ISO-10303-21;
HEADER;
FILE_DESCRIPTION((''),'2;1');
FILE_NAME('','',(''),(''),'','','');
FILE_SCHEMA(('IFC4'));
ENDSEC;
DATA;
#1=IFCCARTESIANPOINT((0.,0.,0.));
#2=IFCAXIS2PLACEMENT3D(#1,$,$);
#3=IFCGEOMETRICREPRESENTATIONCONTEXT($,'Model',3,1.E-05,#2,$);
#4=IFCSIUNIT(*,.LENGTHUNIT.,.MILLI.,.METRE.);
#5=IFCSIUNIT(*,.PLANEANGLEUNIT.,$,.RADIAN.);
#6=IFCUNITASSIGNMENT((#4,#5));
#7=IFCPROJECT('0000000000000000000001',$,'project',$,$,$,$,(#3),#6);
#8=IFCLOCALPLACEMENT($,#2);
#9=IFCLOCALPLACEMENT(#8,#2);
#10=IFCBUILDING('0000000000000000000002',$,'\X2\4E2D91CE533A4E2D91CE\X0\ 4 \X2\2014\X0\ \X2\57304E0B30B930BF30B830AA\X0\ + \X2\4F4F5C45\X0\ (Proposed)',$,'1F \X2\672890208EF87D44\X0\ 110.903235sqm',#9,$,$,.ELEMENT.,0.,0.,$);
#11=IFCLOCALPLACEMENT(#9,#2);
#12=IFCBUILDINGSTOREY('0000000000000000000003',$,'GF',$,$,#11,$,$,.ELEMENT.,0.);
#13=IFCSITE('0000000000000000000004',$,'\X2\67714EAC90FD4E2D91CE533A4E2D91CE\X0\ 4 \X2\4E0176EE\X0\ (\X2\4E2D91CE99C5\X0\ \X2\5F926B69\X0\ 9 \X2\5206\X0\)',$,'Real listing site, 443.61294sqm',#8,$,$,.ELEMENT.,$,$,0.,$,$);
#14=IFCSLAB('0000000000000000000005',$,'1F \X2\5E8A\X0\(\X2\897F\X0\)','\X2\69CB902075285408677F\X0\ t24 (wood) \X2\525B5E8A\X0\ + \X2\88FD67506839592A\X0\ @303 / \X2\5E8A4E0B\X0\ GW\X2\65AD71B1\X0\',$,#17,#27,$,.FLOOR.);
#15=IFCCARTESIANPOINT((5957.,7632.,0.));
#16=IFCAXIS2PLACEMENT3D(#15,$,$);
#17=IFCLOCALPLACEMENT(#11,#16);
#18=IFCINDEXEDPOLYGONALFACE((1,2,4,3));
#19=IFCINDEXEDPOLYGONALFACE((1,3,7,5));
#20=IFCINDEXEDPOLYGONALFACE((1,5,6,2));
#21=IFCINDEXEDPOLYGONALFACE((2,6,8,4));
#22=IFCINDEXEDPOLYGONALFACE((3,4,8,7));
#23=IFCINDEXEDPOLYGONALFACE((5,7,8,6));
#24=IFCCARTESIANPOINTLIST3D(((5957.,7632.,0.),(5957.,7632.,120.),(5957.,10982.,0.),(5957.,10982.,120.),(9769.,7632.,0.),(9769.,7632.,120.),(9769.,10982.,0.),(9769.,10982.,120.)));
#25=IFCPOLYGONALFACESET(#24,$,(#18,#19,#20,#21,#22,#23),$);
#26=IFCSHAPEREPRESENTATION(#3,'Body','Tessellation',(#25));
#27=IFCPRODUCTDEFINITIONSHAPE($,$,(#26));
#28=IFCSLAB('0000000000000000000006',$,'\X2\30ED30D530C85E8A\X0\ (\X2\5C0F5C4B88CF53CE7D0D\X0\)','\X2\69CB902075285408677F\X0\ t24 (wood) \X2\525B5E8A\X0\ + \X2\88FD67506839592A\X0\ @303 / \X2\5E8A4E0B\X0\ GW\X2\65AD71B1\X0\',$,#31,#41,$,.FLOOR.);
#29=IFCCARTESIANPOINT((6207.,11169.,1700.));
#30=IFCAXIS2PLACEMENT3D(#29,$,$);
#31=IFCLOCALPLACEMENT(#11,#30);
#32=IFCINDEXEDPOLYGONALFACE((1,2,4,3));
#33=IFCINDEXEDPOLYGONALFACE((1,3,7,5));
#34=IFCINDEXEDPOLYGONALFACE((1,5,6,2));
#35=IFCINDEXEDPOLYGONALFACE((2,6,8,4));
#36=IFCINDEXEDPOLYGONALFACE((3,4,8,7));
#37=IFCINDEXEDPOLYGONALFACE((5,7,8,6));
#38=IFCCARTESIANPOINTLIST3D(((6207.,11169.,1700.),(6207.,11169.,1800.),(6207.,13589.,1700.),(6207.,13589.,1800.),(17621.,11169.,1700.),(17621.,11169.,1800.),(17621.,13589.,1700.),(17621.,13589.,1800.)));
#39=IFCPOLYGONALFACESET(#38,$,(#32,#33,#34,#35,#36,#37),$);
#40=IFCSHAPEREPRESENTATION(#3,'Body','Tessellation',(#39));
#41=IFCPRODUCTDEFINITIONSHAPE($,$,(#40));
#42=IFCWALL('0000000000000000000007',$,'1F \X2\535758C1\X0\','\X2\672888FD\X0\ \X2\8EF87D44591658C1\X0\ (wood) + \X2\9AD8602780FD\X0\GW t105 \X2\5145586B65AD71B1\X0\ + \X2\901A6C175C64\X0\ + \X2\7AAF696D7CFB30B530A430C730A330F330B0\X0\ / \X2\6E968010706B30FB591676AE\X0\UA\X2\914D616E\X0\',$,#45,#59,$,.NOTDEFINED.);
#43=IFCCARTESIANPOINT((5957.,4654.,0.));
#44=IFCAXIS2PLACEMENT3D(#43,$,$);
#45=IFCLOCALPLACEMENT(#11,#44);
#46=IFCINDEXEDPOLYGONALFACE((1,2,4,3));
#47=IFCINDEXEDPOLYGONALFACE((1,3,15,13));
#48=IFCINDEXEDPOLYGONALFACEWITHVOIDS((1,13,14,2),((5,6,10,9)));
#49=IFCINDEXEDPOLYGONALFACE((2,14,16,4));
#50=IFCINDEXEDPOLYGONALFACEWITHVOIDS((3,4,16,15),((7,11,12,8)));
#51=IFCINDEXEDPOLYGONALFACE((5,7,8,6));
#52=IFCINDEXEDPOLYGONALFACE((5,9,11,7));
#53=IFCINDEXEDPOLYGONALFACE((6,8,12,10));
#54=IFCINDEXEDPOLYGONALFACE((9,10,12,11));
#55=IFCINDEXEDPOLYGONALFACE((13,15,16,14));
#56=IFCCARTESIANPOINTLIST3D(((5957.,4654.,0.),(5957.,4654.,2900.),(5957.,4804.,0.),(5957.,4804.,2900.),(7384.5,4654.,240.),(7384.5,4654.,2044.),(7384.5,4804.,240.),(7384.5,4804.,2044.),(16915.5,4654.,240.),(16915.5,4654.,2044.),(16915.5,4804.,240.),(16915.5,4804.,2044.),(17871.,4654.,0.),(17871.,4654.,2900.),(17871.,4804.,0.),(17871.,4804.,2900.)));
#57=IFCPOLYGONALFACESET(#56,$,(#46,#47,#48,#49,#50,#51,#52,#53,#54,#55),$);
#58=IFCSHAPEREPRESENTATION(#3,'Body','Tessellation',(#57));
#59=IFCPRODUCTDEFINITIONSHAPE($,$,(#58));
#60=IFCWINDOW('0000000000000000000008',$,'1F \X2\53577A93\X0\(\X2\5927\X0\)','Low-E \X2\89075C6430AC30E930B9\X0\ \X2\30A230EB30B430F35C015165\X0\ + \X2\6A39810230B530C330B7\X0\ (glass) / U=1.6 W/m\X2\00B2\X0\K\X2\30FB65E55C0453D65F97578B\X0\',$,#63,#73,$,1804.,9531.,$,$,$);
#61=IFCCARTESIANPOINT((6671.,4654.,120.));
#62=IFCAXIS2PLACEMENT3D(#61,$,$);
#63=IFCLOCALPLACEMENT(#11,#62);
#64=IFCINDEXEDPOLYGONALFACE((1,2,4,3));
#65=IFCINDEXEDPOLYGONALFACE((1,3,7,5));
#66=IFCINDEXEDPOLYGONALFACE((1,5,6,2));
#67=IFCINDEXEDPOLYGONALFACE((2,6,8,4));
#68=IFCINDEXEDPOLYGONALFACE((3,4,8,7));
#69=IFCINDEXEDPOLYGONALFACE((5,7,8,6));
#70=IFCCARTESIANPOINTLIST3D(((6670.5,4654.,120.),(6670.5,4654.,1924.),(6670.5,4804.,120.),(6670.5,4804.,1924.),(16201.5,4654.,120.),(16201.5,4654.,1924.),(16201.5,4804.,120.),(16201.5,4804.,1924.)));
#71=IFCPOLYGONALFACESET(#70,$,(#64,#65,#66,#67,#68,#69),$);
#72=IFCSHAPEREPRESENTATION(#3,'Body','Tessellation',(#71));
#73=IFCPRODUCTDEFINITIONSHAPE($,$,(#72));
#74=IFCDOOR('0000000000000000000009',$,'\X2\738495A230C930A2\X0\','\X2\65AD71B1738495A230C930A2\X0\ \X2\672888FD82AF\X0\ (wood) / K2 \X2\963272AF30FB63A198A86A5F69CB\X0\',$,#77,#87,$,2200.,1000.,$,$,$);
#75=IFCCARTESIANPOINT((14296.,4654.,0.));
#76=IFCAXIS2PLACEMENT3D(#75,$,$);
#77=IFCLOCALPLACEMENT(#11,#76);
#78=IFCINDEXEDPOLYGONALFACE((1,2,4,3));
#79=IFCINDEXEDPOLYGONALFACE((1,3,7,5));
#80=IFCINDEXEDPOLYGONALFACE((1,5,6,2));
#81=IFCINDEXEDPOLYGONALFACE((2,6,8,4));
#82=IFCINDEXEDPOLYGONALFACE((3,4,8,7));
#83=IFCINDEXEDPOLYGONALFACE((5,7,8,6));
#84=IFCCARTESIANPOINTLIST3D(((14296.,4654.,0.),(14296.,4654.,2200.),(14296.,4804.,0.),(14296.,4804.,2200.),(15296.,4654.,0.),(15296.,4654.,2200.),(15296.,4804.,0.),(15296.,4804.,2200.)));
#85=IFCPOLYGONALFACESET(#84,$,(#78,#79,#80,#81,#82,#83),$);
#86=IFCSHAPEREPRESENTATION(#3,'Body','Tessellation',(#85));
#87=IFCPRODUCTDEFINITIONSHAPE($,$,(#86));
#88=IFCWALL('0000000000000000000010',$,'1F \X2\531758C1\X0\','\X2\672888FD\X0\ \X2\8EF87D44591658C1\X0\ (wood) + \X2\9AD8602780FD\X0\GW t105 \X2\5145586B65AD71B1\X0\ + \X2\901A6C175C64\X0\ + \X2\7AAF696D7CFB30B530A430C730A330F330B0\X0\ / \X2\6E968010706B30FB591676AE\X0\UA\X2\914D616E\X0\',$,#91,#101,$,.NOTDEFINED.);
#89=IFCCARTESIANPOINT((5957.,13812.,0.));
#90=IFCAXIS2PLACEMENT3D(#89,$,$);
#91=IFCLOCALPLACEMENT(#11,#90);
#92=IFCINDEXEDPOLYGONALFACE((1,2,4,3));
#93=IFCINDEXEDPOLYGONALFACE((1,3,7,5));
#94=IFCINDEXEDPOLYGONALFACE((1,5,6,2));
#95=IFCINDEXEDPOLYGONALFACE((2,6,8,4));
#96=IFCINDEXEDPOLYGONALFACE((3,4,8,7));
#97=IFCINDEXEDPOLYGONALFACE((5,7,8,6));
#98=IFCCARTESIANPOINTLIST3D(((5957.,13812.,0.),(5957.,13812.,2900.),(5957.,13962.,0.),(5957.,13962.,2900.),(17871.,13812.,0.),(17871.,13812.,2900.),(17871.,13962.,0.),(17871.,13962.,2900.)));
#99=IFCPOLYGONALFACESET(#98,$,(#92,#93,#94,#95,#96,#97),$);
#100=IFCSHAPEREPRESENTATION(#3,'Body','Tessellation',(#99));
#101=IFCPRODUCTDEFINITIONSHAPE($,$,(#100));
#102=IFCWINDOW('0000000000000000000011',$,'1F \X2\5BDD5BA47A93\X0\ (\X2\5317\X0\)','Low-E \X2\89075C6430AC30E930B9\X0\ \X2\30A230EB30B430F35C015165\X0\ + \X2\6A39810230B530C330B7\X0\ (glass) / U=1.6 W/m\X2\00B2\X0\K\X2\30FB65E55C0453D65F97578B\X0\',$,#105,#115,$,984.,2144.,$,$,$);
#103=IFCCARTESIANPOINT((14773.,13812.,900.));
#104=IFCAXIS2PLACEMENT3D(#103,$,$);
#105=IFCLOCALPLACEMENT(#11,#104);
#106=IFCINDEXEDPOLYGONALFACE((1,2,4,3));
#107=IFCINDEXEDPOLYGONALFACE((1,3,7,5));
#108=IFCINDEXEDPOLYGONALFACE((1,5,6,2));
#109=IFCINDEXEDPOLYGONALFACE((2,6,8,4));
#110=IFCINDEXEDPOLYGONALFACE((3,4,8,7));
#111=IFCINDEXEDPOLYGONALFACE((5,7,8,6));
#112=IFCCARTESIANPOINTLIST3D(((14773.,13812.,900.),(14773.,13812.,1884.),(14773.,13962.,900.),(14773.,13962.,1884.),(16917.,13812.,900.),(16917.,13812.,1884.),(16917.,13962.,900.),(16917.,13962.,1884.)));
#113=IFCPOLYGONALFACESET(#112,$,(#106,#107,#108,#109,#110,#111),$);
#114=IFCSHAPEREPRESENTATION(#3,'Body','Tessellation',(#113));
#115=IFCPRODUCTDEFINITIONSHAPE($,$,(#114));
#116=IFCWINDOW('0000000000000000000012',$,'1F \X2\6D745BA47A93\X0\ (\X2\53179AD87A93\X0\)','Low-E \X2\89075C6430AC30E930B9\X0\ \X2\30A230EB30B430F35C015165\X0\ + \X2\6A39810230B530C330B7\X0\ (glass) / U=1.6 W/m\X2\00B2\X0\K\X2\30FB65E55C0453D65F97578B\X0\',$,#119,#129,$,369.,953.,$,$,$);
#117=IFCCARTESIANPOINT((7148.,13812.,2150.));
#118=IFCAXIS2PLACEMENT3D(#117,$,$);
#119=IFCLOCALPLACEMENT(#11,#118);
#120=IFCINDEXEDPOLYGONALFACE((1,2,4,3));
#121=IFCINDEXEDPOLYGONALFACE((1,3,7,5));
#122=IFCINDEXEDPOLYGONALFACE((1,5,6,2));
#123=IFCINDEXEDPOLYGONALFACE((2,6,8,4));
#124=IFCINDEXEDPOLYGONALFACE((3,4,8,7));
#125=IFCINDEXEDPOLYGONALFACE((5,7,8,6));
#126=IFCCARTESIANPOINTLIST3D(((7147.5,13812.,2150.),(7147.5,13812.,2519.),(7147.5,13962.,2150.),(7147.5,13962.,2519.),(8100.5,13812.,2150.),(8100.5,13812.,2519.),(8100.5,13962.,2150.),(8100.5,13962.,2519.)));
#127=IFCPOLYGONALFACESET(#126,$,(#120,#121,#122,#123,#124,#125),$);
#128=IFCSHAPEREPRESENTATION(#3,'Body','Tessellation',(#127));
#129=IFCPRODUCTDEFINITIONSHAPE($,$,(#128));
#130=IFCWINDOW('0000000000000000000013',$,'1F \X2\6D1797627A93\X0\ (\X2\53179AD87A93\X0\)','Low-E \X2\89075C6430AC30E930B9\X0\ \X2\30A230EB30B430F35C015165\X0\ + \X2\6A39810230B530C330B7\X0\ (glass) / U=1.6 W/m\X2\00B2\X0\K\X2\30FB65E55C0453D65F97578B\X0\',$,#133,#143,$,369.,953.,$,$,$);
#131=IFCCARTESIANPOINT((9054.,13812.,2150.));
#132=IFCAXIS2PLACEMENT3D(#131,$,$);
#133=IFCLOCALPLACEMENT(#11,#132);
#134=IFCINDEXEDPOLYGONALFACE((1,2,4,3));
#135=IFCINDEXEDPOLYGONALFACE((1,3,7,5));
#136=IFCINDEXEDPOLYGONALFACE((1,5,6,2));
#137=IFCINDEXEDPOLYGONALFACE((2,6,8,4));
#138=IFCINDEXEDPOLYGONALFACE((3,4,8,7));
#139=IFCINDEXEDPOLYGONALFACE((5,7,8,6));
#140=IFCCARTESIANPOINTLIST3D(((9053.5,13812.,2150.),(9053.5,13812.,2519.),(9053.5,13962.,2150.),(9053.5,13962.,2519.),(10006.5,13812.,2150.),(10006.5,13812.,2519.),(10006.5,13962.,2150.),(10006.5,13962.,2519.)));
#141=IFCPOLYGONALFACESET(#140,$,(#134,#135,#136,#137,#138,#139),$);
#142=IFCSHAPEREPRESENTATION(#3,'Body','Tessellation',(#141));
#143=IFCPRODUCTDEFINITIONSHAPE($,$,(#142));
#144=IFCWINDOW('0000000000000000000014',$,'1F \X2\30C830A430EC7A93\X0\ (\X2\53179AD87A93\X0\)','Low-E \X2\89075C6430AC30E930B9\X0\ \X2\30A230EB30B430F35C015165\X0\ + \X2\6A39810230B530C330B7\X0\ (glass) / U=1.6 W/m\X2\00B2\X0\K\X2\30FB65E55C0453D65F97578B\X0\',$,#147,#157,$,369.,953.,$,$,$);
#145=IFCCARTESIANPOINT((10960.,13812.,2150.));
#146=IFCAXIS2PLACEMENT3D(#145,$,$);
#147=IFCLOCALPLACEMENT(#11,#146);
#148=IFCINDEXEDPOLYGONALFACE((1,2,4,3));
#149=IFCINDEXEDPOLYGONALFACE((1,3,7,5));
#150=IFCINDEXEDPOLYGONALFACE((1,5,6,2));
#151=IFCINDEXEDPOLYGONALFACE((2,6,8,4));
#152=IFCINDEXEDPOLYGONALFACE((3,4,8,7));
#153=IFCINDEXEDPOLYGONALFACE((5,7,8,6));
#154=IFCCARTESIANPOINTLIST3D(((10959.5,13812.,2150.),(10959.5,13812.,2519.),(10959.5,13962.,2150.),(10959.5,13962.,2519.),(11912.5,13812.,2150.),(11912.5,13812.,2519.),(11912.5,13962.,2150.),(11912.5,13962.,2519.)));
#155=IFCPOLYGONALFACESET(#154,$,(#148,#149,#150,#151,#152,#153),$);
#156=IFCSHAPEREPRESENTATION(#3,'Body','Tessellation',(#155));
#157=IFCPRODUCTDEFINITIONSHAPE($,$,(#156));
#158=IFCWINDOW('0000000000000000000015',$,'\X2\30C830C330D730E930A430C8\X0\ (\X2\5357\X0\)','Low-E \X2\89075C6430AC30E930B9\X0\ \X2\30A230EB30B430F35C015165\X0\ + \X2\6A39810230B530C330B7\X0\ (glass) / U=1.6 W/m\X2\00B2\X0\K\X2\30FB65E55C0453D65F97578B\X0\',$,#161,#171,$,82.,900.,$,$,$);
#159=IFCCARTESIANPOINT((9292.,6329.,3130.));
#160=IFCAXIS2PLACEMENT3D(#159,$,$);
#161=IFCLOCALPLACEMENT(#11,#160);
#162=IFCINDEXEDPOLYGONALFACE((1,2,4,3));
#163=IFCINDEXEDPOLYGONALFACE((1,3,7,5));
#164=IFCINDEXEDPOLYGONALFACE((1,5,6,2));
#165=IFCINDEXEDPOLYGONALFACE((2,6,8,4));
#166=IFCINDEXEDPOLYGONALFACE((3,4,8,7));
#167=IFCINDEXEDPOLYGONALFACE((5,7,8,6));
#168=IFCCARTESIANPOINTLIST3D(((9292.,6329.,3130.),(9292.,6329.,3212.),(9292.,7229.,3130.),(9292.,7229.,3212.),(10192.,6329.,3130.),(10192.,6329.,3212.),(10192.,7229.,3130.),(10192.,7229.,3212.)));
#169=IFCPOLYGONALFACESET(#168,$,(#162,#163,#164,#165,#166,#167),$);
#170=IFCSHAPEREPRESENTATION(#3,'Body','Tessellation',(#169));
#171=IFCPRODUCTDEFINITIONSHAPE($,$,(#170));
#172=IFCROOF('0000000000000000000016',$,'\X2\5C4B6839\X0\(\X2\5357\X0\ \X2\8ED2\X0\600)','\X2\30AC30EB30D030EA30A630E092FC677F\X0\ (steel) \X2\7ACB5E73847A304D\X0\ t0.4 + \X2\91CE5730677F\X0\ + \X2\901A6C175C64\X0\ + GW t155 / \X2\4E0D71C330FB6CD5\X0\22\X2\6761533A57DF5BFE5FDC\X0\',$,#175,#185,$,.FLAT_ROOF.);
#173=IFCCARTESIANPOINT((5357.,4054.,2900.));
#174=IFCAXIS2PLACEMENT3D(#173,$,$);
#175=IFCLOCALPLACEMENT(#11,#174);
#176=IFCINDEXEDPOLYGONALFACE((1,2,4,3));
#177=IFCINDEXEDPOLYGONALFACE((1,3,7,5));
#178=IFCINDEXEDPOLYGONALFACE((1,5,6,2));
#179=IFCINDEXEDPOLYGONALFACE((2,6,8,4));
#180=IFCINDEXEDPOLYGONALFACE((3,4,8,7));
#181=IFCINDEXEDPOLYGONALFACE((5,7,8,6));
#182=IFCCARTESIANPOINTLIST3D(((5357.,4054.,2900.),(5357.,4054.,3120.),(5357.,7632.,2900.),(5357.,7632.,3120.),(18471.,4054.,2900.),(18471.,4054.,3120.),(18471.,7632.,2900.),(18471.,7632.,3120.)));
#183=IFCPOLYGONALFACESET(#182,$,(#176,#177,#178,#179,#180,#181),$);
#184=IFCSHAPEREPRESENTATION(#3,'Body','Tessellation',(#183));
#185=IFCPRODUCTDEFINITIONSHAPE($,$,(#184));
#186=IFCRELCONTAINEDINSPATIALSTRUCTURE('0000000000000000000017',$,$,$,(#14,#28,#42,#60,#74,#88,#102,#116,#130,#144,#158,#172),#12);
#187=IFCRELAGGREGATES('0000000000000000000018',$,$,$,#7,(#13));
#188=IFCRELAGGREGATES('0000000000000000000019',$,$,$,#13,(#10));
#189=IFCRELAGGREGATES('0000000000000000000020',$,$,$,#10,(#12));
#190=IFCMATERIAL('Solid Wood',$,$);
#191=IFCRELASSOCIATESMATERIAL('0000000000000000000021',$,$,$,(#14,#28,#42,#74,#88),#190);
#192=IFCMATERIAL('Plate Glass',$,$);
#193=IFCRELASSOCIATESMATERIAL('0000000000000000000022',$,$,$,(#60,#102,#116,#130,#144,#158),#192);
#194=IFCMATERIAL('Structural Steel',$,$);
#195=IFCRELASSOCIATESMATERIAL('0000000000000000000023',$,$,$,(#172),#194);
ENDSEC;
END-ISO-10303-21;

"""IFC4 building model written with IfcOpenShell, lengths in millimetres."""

from ifc_helpers import new_model, si_unit, frame, frame_2d, origin, place, context, project, spatial, rectangle, extrude, material, element, fill, save


model = new_model("IFC4")

# Units and contexts
model_context = context("Model", 3, precision=1e-05, world=origin())
ifc_project = project(units=[si_unit("LENGTHUNIT", "METRE", prefix="MILLI"), si_unit("PLANEANGLEUNIT", "RADIAN")], contexts=[model_context])

# Site, building, storey
site_placement = place(None, origin())
site = spatial("IfcSite", under=ifc_project, at=site_placement, Name="東京都中野区中野 4 丁目 (中野駅 徒歩 9 分)", ObjectType="Real listing site, 443.61294sqm", CompositionType="ELEMENT", RefElevation=0.0)
building_placement = place(site_placement, origin())
building = spatial("IfcBuilding", under=site, at=building_placement, Name="中野区中野 4 — 地下スタジオ + 住居 (Proposed)", ObjectType="1F 木造軸組 110.903235sqm", CompositionType="ELEMENT", ElevationOfRefHeight=0.0, ElevationOfTerrain=0.0)
storey_placement = place(building_placement, origin())
storey = spatial("IfcBuildingStorey", under=building, at=storey_placement, Name="GF", CompositionType="ELEMENT", Elevation=0.0)

# Slabs
ifc_material_1 = material(Name="Solid Wood")
slab_1_placement = place(storey_placement, frame((5957.0, 7632.0, 0.0)))
element("IfcSlab", 1, at=slab_1_placement, inside=storey, material=ifc_material_1, Name="1F 床(西)", Description="構造用合板 t24 (wood) 剛床 + 製材根太 @303 / 床下 GW断熱", PredefinedType="FLOOR", context=model_context, shape_type="SweptSolid", body=[
    extrude(rectangle(XDim=3812.0, YDim=3350.0, at=frame_2d((1906.0, 1675.0))), frame((5957.0, 7632.0, 0.0)), (0.0, 0.0, 1.0), 120.0),
])
slab_2_placement = place(storey_placement, frame((6207.0, 11169.0, 1700.0)))
element("IfcSlab", 2, at=slab_2_placement, inside=storey, material=ifc_material_1, Name="ロフト床 (小屋裏収納)", Description="構造用合板 t24 (wood) 剛床 + 製材根太 @303 / 床下 GW断熱", PredefinedType="FLOOR", context=model_context, shape_type="SweptSolid", body=[
    extrude(rectangle(XDim=11414.0, YDim=2420.0, at=frame_2d((5707.0, 1210.0))), frame((6207.0, 11169.0, 1700.0)), (0.0, 0.0, 1.0), 100.0),
])

# Wall, openings, window, door
wall_1_placement = place(storey_placement, frame((5957.0, 4654.0, 0.0)))
wall_1 = element("IfcWall", 3, at=wall_1_placement, inside=storey, material=ifc_material_1, Name="1F 南壁", Description="木製 軸組外壁 (wood) + 高性能GW t105 充填断熱 + 通気層 + 窯業系サイディング / 準耐火・外皮UA配慮", PredefinedType="NOTDEFINED", context=model_context, shape_type="SweptSolid", body=[
    extrude(rectangle(XDim=11914.0, YDim=150.0, at=frame_2d((5957.0, 75.0))), frame((5957.0, 4654.0, 0.0)), (0.0, 0.0, 1.0), 2900.0),
])
opening_1_placement = place(storey_placement, frame((6671.0, 4654.0, 120.0)))
opening_1 = element("IfcOpeningElement", 4, at=opening_1_placement, cuts=wall_1, PredefinedType="NOTDEFINED", context=model_context, shape_type="SweptSolid", body=[
    extrude(rectangle(XDim=9531.0, YDim=150.0, at=frame_2d((4765.0, 75.0))), frame((6671.0, 4654.0, 120.0)), (0.0, 0.0, 1.0), 1804.0),
])
opening_2_placement = place(storey_placement, frame((14296.0, 4654.0, 0.0)))
opening_2 = element("IfcOpeningElement", 5, at=opening_2_placement, cuts=wall_1, PredefinedType="NOTDEFINED", context=model_context, shape_type="SweptSolid", body=[
    extrude(rectangle(XDim=1000.0, YDim=150.0, at=frame_2d((500.0, 75.0))), frame((14296.0, 4654.0, 0.0)), (0.0, 0.0, 1.0), 2200.0),
])
ifc_material_2 = material(Name="Plate Glass")
window_1_placement = place(storey_placement, frame((6671.0, 4654.0, 120.0)))
window_1 = element("IfcWindow", 6, at=window_1_placement, inside=storey, material=ifc_material_2, Name="1F 南窓(大)", Description="Low-E 複層ガラス アルゴン封入 + 樹脂サッシ (glass) / U=1.6 W/m²K・日射取得型", OverallHeight=1804.0, OverallWidth=9531.0, context=model_context, shape_type="SweptSolid", body=[
    extrude(rectangle(XDim=9531.0, YDim=150.0, at=frame_2d((4765.0, 75.0))), frame((6671.0, 4654.0, 120.0)), (0.0, 0.0, 1.0), 1804.0),
])
fill(opening_1, window_1)
door_1_placement = place(storey_placement, frame((14296.0, 4654.0, 0.0)))
door_1 = element("IfcDoor", 7, at=door_1_placement, inside=storey, material=ifc_material_1, Name="玄関ドア", Description="断熱玄関ドア 木製芯 (wood) / K2 防犯・採風機構", OverallHeight=2200.0, OverallWidth=1000.0, context=model_context, shape_type="SweptSolid", body=[
    extrude(rectangle(XDim=1000.0, YDim=150.0, at=frame_2d((500.0, 75.0))), frame((14296.0, 4654.0, 0.0)), (0.0, 0.0, 1.0), 2200.0),
])
fill(opening_2, door_1)

# Wall, openings, windows
wall_2_placement = place(storey_placement, frame((5957.0, 13812.0, 0.0)))
wall_2 = element("IfcWall", 8, at=wall_2_placement, inside=storey, material=ifc_material_1, Name="1F 北壁", Description="木製 軸組外壁 (wood) + 高性能GW t105 充填断熱 + 通気層 + 窯業系サイディング / 準耐火・外皮UA配慮", PredefinedType="NOTDEFINED", context=model_context, shape_type="SweptSolid", body=[
    extrude(rectangle(XDim=11914.0, YDim=150.0, at=frame_2d((5957.0, 75.0))), frame((5957.0, 13812.0, 0.0)), (0.0, 0.0, 1.0), 2900.0),
])
opening_3_placement = place(storey_placement, frame((14773.0, 13812.0, 900.0)))
opening_3 = element("IfcOpeningElement", 9, at=opening_3_placement, cuts=wall_2, PredefinedType="NOTDEFINED", context=model_context, shape_type="SweptSolid", body=[
    extrude(rectangle(XDim=2144.0, YDim=150.0, at=frame_2d((1072.0, 75.0))), frame((14773.0, 13812.0, 900.0)), (0.0, 0.0, 1.0), 984.0),
])
opening_4_placement = place(storey_placement, frame((7148.0, 13812.0, 2150.0)))
opening_4 = element("IfcOpeningElement", 10, at=opening_4_placement, cuts=wall_2, PredefinedType="NOTDEFINED", context=model_context, shape_type="SweptSolid", body=[
    extrude(rectangle(XDim=953.0, YDim=150.0, at=frame_2d((476.0, 75.0))), frame((7148.0, 13812.0, 2150.0)), (0.0, 0.0, 1.0), 369.0),
])
opening_5_placement = place(storey_placement, frame((9054.0, 13812.0, 2150.0)))
opening_5 = element("IfcOpeningElement", 11, at=opening_5_placement, cuts=wall_2, PredefinedType="NOTDEFINED", context=model_context, shape_type="SweptSolid", body=[
    extrude(rectangle(XDim=953.0, YDim=150.0, at=frame_2d((476.0, 75.0))), frame((9054.0, 13812.0, 2150.0)), (0.0, 0.0, 1.0), 369.0),
])
opening_6_placement = place(storey_placement, frame((10960.0, 13812.0, 2150.0)))
opening_6 = element("IfcOpeningElement", 12, at=opening_6_placement, cuts=wall_2, PredefinedType="NOTDEFINED", context=model_context, shape_type="SweptSolid", body=[
    extrude(rectangle(XDim=953.0, YDim=150.0, at=frame_2d((476.0, 75.0))), frame((10960.0, 13812.0, 2150.0)), (0.0, 0.0, 1.0), 369.0),
])
window_2_placement = place(storey_placement, frame((14773.0, 13812.0, 900.0)))
window_2 = element("IfcWindow", 13, at=window_2_placement, inside=storey, material=ifc_material_2, Name="1F 寝室窓 (北)", Description="Low-E 複層ガラス アルゴン封入 + 樹脂サッシ (glass) / U=1.6 W/m²K・日射取得型", OverallHeight=984.0, OverallWidth=2144.0, context=model_context, shape_type="SweptSolid", body=[
    extrude(rectangle(XDim=2144.0, YDim=150.0, at=frame_2d((1072.0, 75.0))), frame((14773.0, 13812.0, 900.0)), (0.0, 0.0, 1.0), 984.0),
])
fill(opening_3, window_2)
window_3_placement = place(storey_placement, frame((7148.0, 13812.0, 2150.0)))
window_3 = element("IfcWindow", 14, at=window_3_placement, inside=storey, material=ifc_material_2, Name="1F 浴室窓 (北高窓)", Description="Low-E 複層ガラス アルゴン封入 + 樹脂サッシ (glass) / U=1.6 W/m²K・日射取得型", OverallHeight=369.0, OverallWidth=953.0, context=model_context, shape_type="SweptSolid", body=[
    extrude(rectangle(XDim=953.0, YDim=150.0, at=frame_2d((476.0, 75.0))), frame((7148.0, 13812.0, 2150.0)), (0.0, 0.0, 1.0), 369.0),
])
fill(opening_4, window_3)
window_4_placement = place(storey_placement, frame((9054.0, 13812.0, 2150.0)))
window_4 = element("IfcWindow", 15, at=window_4_placement, inside=storey, material=ifc_material_2, Name="1F 洗面窓 (北高窓)", Description="Low-E 複層ガラス アルゴン封入 + 樹脂サッシ (glass) / U=1.6 W/m²K・日射取得型", OverallHeight=369.0, OverallWidth=953.0, context=model_context, shape_type="SweptSolid", body=[
    extrude(rectangle(XDim=953.0, YDim=150.0, at=frame_2d((476.0, 75.0))), frame((9054.0, 13812.0, 2150.0)), (0.0, 0.0, 1.0), 369.0),
])
fill(opening_5, window_4)
window_5_placement = place(storey_placement, frame((10960.0, 13812.0, 2150.0)))
window_5 = element("IfcWindow", 16, at=window_5_placement, inside=storey, material=ifc_material_2, Name="1F トイレ窓 (北高窓)", Description="Low-E 複層ガラス アルゴン封入 + 樹脂サッシ (glass) / U=1.6 W/m²K・日射取得型", OverallHeight=369.0, OverallWidth=953.0, context=model_context, shape_type="SweptSolid", body=[
    extrude(rectangle(XDim=953.0, YDim=150.0, at=frame_2d((476.0, 75.0))), frame((10960.0, 13812.0, 2150.0)), (0.0, 0.0, 1.0), 369.0),
])
fill(opening_6, window_5)

# Window
window_6_placement = place(storey_placement, frame((9292.0, 6329.0, 3130.0)))
element("IfcWindow", 17, at=window_6_placement, inside=storey, material=ifc_material_2, Name="トップライト (南)", Description="Low-E 複層ガラス アルゴン封入 + 樹脂サッシ (glass) / U=1.6 W/m²K・日射取得型", OverallHeight=82.0, OverallWidth=900.0, context=model_context, shape_type="SweptSolid", body=[
    extrude(rectangle(XDim=900.0, YDim=900.0, at=frame_2d((450.0, 450.0))), frame((9292.0, 6329.0, 3130.0)), (0.0, 0.0, 1.0), 82.0),
])

# Roof
ifc_material_3 = material(Name="Structural Steel")
roof_1_placement = place(storey_placement, frame((5357.0, 4054.0, 2900.0)))
element("IfcRoof", 18, at=roof_1_placement, inside=storey, material=ifc_material_3, Name="屋根(南 軒600)", Description="ガルバリウム鋼板 (steel) 立平葺き t0.4 + 野地板 + 通気層 + GW t155 / 不燃・法22条区域対応", PredefinedType="FLAT_ROOF", context=model_context, shape_type="SweptSolid", body=[
    extrude(rectangle(XDim=13114.0, YDim=3578.0, at=frame_2d((6557.0, 1789.0))), frame((5357.0, 4054.0, 2900.0)), (0.0, 0.0, 1.0), 220.0),
])

save(model, "model.ifc")
